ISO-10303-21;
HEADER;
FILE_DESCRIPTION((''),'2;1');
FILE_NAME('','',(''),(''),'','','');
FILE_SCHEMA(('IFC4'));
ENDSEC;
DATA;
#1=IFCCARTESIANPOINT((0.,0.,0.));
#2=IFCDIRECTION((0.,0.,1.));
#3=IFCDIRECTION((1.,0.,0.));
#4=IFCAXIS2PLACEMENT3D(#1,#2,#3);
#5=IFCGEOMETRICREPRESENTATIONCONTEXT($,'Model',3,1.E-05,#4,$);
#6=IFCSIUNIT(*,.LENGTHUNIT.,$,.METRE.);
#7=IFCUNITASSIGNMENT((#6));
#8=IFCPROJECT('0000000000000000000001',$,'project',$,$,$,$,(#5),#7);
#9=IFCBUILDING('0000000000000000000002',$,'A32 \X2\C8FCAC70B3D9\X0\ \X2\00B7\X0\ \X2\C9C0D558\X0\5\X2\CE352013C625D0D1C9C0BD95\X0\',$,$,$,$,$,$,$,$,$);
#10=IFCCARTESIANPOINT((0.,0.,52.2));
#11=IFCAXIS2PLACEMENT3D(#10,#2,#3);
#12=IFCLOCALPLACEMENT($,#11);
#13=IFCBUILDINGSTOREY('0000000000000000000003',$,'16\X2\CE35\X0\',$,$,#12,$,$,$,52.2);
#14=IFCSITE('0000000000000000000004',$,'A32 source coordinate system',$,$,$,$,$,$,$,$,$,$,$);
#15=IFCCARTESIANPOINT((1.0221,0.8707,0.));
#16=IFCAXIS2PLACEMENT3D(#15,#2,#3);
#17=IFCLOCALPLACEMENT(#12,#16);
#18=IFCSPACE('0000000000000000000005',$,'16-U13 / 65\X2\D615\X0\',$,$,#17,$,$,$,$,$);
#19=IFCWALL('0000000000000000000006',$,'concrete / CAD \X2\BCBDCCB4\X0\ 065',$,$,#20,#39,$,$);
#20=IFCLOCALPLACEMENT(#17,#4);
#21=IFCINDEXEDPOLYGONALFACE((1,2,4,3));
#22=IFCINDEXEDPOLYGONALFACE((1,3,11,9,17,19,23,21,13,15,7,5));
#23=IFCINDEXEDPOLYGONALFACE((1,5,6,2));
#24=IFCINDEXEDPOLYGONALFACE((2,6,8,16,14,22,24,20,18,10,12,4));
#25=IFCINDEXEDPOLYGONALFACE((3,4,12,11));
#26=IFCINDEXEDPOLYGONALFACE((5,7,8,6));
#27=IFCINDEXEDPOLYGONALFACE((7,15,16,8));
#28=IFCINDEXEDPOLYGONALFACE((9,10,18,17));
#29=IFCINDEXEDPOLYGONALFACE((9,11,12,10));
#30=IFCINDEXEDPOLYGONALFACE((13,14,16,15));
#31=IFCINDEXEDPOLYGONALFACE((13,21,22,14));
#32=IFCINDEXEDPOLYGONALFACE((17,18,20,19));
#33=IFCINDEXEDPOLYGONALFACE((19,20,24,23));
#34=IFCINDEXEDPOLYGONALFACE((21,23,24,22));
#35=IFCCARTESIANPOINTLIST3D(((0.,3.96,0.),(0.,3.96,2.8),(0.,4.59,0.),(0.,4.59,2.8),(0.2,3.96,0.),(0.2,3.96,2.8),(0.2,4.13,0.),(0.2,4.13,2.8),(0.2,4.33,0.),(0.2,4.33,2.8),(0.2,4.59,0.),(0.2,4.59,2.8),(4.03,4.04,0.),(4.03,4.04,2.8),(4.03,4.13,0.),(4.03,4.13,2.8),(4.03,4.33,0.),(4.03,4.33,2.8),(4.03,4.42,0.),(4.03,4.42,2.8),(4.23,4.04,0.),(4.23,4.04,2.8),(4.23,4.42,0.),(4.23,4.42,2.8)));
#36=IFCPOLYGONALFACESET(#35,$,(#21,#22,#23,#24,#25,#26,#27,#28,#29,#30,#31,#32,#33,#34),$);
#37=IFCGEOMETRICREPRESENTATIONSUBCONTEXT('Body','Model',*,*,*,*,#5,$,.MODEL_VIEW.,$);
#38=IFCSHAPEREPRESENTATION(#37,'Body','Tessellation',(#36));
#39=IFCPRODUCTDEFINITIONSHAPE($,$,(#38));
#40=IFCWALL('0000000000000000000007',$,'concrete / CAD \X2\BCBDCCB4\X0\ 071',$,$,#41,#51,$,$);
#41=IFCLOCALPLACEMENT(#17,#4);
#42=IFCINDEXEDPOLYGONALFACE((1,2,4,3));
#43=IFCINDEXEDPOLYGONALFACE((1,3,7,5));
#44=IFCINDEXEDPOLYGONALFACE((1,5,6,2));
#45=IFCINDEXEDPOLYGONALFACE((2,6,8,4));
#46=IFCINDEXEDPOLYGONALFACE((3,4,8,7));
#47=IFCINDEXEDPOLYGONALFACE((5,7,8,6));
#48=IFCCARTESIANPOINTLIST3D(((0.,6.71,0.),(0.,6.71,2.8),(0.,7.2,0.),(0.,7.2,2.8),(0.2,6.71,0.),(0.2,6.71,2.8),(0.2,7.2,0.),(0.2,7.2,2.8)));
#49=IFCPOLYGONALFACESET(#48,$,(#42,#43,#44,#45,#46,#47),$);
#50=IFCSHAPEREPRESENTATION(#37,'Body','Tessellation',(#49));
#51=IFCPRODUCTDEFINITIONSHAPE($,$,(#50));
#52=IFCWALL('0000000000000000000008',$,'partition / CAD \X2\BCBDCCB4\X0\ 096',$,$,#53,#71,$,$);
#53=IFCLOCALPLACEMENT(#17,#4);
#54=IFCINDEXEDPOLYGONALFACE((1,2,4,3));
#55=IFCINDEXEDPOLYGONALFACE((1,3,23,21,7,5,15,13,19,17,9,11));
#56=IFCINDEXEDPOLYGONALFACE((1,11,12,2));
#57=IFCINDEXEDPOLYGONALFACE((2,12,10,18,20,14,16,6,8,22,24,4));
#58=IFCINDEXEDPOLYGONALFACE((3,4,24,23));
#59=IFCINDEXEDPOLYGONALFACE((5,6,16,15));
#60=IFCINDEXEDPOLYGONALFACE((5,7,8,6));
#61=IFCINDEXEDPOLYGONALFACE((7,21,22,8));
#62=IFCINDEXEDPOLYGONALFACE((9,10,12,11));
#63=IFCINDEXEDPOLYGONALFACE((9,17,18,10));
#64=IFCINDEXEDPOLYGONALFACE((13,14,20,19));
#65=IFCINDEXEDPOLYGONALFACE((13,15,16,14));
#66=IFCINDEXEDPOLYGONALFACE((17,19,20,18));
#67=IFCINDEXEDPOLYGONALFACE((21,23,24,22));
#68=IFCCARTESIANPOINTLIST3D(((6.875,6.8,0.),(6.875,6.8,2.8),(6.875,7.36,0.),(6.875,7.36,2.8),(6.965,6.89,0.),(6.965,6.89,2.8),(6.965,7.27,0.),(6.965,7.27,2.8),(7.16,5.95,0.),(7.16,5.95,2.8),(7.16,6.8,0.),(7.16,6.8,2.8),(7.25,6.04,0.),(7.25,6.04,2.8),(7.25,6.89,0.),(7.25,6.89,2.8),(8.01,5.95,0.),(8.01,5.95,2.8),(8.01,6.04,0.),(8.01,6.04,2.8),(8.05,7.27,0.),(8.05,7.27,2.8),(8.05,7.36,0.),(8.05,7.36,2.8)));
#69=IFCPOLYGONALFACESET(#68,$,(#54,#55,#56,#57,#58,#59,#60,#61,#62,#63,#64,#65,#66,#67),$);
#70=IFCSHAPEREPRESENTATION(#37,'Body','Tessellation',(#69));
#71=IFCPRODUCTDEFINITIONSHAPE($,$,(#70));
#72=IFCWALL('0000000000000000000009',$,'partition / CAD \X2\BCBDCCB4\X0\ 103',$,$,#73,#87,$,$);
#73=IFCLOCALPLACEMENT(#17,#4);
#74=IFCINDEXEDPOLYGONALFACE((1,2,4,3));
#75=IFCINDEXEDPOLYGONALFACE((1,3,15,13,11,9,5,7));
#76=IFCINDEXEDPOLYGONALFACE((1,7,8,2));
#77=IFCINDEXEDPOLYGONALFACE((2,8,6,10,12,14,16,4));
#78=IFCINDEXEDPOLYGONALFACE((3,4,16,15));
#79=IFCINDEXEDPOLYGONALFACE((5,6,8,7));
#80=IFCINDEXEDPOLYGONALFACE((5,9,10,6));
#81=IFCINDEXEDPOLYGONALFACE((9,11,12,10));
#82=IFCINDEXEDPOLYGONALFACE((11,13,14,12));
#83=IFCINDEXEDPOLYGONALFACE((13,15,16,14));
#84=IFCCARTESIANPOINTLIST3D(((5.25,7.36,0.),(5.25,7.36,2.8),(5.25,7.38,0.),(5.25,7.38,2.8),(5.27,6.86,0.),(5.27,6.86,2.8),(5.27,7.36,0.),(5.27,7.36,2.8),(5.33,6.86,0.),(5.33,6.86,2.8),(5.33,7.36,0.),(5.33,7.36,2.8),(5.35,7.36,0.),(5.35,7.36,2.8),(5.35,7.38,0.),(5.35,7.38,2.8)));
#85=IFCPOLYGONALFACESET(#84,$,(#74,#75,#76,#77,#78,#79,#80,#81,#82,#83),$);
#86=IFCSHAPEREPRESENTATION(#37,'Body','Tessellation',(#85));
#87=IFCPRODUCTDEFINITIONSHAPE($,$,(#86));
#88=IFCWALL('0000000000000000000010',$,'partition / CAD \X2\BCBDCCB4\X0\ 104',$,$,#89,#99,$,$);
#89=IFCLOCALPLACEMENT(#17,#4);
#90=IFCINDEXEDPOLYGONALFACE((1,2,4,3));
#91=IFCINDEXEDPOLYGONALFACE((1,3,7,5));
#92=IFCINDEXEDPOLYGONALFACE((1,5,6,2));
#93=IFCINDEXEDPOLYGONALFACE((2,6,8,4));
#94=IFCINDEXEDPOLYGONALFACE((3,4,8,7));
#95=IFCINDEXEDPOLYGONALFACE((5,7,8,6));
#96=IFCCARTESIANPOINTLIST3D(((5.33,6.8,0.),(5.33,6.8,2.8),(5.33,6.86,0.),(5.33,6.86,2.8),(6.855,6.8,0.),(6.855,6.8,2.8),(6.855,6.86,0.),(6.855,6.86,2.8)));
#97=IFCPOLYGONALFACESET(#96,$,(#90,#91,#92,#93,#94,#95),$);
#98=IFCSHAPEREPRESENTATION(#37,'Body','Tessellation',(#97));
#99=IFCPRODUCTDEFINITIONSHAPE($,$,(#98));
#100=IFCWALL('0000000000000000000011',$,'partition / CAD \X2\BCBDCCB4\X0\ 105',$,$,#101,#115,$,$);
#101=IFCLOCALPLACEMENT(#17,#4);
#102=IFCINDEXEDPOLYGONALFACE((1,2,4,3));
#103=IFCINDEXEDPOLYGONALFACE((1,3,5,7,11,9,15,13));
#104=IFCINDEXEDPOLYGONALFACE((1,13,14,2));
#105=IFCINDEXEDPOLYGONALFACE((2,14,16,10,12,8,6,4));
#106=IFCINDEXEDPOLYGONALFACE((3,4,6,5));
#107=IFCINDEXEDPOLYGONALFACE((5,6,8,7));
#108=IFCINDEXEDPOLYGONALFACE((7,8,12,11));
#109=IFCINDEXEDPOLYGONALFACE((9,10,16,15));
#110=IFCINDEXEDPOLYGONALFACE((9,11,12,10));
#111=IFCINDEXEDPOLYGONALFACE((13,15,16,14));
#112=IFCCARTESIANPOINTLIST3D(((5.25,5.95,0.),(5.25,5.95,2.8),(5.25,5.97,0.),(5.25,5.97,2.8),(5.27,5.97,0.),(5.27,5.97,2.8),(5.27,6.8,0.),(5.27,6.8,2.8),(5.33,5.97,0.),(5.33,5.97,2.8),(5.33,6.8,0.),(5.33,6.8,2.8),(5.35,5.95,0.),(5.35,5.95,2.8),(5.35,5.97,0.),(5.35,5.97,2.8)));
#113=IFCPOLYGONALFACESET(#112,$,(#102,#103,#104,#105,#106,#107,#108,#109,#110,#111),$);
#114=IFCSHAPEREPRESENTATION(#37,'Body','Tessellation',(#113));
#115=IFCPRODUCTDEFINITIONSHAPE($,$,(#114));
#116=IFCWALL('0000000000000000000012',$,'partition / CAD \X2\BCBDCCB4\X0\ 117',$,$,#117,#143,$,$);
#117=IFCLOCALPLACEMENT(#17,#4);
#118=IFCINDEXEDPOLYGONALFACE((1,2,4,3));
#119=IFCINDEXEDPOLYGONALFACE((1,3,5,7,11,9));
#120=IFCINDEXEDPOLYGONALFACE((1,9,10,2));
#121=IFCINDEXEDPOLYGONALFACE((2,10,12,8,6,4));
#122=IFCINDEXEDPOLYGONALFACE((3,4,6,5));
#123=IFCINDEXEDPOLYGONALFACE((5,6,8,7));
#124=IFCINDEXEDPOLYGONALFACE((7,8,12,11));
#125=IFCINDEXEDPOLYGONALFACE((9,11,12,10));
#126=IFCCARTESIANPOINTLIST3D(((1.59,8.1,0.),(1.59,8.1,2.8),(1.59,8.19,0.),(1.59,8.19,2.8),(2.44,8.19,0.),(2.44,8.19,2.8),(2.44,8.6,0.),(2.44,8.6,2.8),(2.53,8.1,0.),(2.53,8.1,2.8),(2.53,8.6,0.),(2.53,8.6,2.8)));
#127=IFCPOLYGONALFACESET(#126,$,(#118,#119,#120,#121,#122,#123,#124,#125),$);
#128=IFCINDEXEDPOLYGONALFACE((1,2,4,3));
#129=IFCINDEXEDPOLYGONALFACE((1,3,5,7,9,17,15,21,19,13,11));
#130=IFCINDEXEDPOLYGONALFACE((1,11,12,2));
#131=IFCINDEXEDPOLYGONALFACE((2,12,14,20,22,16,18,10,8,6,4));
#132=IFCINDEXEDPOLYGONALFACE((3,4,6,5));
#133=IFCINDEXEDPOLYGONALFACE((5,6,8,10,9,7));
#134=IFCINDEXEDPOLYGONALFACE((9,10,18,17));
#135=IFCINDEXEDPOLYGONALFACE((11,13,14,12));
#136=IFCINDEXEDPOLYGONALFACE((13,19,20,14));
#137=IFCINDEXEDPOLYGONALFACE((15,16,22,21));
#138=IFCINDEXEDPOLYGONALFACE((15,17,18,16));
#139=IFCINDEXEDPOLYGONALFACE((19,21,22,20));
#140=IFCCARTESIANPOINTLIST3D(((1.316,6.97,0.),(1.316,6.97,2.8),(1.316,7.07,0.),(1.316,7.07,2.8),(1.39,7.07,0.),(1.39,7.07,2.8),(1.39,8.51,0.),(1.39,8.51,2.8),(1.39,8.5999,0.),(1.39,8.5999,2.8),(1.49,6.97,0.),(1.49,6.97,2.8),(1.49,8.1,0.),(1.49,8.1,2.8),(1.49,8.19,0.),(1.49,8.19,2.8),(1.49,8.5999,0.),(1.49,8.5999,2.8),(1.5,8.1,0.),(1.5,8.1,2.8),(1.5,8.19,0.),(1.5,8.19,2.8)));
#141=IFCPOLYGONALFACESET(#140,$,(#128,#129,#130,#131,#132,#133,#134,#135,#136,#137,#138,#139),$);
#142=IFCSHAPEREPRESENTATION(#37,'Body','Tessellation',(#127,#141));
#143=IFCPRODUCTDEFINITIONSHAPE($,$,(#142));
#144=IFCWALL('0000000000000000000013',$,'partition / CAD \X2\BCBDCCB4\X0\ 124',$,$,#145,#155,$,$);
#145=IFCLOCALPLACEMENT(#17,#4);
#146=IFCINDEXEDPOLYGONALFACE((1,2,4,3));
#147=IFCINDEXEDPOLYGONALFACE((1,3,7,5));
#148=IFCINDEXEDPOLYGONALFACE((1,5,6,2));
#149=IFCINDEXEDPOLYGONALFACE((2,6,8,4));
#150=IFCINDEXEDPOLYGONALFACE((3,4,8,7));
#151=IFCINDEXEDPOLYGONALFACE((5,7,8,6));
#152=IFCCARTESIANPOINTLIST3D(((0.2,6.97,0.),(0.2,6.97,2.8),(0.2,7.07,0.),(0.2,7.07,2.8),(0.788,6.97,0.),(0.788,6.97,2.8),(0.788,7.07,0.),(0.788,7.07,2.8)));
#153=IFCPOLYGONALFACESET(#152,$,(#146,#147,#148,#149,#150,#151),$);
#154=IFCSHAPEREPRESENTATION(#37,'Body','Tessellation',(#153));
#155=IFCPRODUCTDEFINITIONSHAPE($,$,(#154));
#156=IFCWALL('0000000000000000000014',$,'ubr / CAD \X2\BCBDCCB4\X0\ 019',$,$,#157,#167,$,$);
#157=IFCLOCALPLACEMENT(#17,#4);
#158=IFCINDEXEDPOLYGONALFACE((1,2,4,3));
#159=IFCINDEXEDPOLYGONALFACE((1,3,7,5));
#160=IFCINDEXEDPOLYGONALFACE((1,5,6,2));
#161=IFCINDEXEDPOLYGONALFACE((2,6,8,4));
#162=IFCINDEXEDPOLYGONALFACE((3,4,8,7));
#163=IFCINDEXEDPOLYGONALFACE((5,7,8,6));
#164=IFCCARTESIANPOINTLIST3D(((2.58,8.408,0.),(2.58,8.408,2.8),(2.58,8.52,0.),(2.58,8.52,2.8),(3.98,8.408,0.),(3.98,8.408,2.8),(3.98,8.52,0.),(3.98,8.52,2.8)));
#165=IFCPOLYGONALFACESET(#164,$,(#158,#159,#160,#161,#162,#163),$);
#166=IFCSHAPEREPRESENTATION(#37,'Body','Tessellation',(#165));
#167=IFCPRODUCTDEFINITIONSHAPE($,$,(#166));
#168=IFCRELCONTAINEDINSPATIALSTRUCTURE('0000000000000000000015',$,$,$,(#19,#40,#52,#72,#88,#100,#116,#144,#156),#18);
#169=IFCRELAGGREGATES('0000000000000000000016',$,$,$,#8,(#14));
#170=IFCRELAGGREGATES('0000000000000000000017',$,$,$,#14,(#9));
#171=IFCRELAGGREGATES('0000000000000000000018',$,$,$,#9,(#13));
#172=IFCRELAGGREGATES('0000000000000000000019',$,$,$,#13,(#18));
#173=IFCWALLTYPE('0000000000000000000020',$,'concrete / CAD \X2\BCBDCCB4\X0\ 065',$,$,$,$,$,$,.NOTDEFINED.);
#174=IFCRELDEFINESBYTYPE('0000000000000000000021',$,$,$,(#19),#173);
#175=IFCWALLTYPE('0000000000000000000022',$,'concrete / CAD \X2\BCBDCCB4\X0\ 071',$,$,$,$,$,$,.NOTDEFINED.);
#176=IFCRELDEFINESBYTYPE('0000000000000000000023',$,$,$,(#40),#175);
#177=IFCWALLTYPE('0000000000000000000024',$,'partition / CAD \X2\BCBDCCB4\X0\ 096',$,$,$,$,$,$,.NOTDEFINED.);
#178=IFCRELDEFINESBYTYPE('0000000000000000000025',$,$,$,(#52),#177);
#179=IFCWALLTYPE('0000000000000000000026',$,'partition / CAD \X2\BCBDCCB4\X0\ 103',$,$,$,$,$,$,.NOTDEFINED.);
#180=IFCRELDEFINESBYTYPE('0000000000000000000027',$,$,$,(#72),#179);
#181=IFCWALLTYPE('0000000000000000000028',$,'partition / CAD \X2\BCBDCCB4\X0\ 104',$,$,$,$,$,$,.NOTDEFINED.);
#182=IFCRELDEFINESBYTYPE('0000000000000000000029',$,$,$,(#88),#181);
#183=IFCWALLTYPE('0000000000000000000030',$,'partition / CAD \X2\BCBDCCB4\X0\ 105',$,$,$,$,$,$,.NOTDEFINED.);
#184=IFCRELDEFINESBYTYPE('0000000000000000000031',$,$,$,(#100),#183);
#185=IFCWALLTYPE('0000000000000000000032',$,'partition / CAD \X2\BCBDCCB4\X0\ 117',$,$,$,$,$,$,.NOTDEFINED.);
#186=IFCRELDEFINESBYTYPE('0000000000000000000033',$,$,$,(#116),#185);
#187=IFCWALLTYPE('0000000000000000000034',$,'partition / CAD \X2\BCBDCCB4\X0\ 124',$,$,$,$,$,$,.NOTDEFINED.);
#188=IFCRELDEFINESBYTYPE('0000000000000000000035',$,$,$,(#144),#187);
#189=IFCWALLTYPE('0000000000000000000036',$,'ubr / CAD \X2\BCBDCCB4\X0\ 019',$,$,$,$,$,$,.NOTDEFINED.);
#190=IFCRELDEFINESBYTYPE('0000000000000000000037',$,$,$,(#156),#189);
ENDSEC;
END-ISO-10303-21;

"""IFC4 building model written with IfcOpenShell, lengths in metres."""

from ifc_helpers import new_model, si_unit, frame, origin, origin_with_axes, place, context, subcontext, project, spatial, polyline, outline, extrude, source, transform, mapped, type_object, type_shapes, element, save


model = new_model("IFC4")

# Units and contexts
model_context = context("Model", 3, precision=1e-05, world=origin_with_axes())
body_context = subcontext(model_context, "Body", "Model", "MODEL_VIEW")
ifc_project = project(units=[si_unit("LENGTHUNIT", "METRE")], contexts=[model_context])

# Site, building, storey, space
storey_placement = place(None, frame((0.0, 0.0, 52.2), z_axis=(0.0, 0.0, 1.0), x_axis=(1.0, 0.0, 0.0)))
space_placement = place(storey_placement, frame((1.0221, 0.8707, 0.0), z_axis=(0.0, 0.0, 1.0), x_axis=(1.0, 0.0, 0.0)))
site = spatial("IfcSite", under=ifc_project, Name="A32 source coordinate system")
building = spatial("IfcBuilding", under=site, Name="A32 주거동 · 지하5층–옥탑지붕")
storey = spatial("IfcBuildingStorey", under=building, at=storey_placement, Name="16층", Elevation=52.2)
space = spatial("IfcSpace", under=storey, at=space_placement, Name="16-U13 / 65형")

# Walls
wall_type_1 = type_object("IfcWallType", Name="concrete / CAD 벽체 065", PredefinedType="NOTDEFINED")
shared_shape_1 = source(origin(), body_context, "Body", "SweptSolid", [
    extrude(outline(polyline([(0.2, 4.59), (0.2, 4.33), (4.03, 4.33), (4.03, 4.42), (4.23, 4.42), (4.23, 4.04), (4.03, 4.04), (4.03, 4.13), (0.2, 4.13), (0.2, 3.96), (0.0, 3.96), (0.0, 4.59), (0.2, 4.59)])), origin(), (0.0, 0.0, 1.0), 2.8),
])
type_shapes(wall_type_1, [shared_shape_1])
wall_1_placement = place(space_placement, origin_with_axes())
element("IfcWall", 1, at=wall_1_placement, inside=space, type_object=wall_type_1, Name="concrete / CAD 벽체 065", context=body_context, shape_type="MappedRepresentation", body=[
    mapped(shared_shape_1, transform((0.0, 0.0, 0.0), scale=1.0)),
])
wall_type_2 = type_object("IfcWallType", Name="concrete / CAD 벽체 071", PredefinedType="NOTDEFINED")
shared_shape_2 = source(origin(), body_context, "Body", "SweptSolid", [
    extrude(outline(polyline([(0.2, 6.71), (0.0, 6.71), (0.0, 7.2), (0.2, 7.2), (0.2, 6.71)])), origin(), (0.0, 0.0, 1.0), 2.8),
])
type_shapes(wall_type_2, [shared_shape_2])
wall_2_placement = place(space_placement, origin_with_axes())
element("IfcWall", 2, at=wall_2_placement, inside=space, type_object=wall_type_2, Name="concrete / CAD 벽체 071", context=body_context, shape_type="MappedRepresentation", body=[
    mapped(shared_shape_2, transform((0.0, 0.0, 0.0), scale=1.0)),
])
wall_type_3 = type_object("IfcWallType", Name="partition / CAD 벽체 096", PredefinedType="NOTDEFINED")
shared_shape_3 = source(origin(), body_context, "Body", "SweptSolid", [
    extrude(outline(polyline([(7.25, 6.04), (8.01, 6.04), (8.01, 5.95), (7.16, 5.95), (7.16, 6.8), (6.875, 6.8), (6.875, 7.36), (8.05, 7.36), (8.05, 7.27), (6.965, 7.27), (6.965, 6.89), (7.25, 6.89), (7.25, 6.04)])), origin(), (0.0, 0.0, 1.0), 2.8),
])
type_shapes(wall_type_3, [shared_shape_3])
wall_3_placement = place(space_placement, origin_with_axes())
element("IfcWall", 3, at=wall_3_placement, inside=space, type_object=wall_type_3, Name="partition / CAD 벽체 096", context=body_context, shape_type="MappedRepresentation", body=[
    mapped(shared_shape_3, transform((0.0, 0.0, 0.0), scale=1.0)),
])
wall_type_4 = type_object("IfcWallType", Name="partition / CAD 벽체 103", PredefinedType="NOTDEFINED")
shared_shape_4 = source(origin(), body_context, "Body", "SweptSolid", [
    extrude(outline(polyline([(5.27, 7.36), (5.25, 7.36), (5.25, 7.38), (5.35, 7.38), (5.35, 7.36), (5.33, 7.36), (5.33, 6.86), (5.27, 6.86), (5.27, 7.36)])), origin(), (0.0, 0.0, 1.0), 2.8),
])
type_shapes(wall_type_4, [shared_shape_4])
wall_4_placement = place(space_placement, origin_with_axes())
element("IfcWall", 4, at=wall_4_placement, inside=space, type_object=wall_type_4, Name="partition / CAD 벽체 103", context=body_context, shape_type="MappedRepresentation", body=[
    mapped(shared_shape_4, transform((0.0, 0.0, 0.0), scale=1.0)),
])
wall_type_5 = type_object("IfcWallType", Name="partition / CAD 벽체 104", PredefinedType="NOTDEFINED")
shared_shape_5 = source(origin(), body_context, "Body", "SweptSolid", [
    extrude(outline(polyline([(6.855, 6.86), (6.855, 6.8), (5.33, 6.8), (5.33, 6.86), (6.855, 6.86)])), origin(), (0.0, 0.0, 1.0), 2.8),
])
type_shapes(wall_type_5, [shared_shape_5])
wall_5_placement = place(space_placement, origin_with_axes())
element("IfcWall", 5, at=wall_5_placement, inside=space, type_object=wall_type_5, Name="partition / CAD 벽체 104", context=body_context, shape_type="MappedRepresentation", body=[
    mapped(shared_shape_5, transform((0.0, 0.0, 0.0), scale=1.0)),
])
wall_type_6 = type_object("IfcWallType", Name="partition / CAD 벽체 105", PredefinedType="NOTDEFINED")
shared_shape_6 = source(origin(), body_context, "Body", "SweptSolid", [
    extrude(outline(polyline([(5.25, 5.97), (5.27, 5.97), (5.27, 6.8), (5.33, 6.8), (5.33, 5.97), (5.35, 5.97), (5.35, 5.95), (5.25, 5.95), (5.25, 5.97)])), origin(), (0.0, 0.0, 1.0), 2.8),
])
type_shapes(wall_type_6, [shared_shape_6])
wall_6_placement = place(space_placement, origin_with_axes())
element("IfcWall", 6, at=wall_6_placement, inside=space, type_object=wall_type_6, Name="partition / CAD 벽체 105", context=body_context, shape_type="MappedRepresentation", body=[
    mapped(shared_shape_6, transform((0.0, 0.0, 0.0), scale=1.0)),
])
wall_type_7 = type_object("IfcWallType", Name="partition / CAD 벽체 117", PredefinedType="NOTDEFINED")
shared_shape_7 = source(origin(), body_context, "Body", "SweptSolid", [
    extrude(outline(polyline([(2.53, 8.1), (1.59, 8.1), (1.59, 8.19), (2.44, 8.19), (2.44, 8.6), (2.53, 8.6), (2.53, 8.1)])), origin(), (0.0, 0.0, 1.0), 2.8),
    extrude(outline(polyline([(1.49, 8.1), (1.49, 6.97), (1.316, 6.97), (1.316, 7.07), (1.39, 7.07), (1.39, 8.51), (1.39, 8.5999), (1.49, 8.5999), (1.49, 8.19), (1.5, 8.19), (1.5, 8.1), (1.49, 8.1)])), origin(), (0.0, 0.0, 1.0), 2.8),
])
type_shapes(wall_type_7, [shared_shape_7])
wall_7_placement = place(space_placement, origin_with_axes())
element("IfcWall", 7, at=wall_7_placement, inside=space, type_object=wall_type_7, Name="partition / CAD 벽체 117", context=body_context, shape_type="MappedRepresentation", body=[
    mapped(shared_shape_7, transform((0.0, 0.0, 0.0), scale=1.0)),
])
wall_type_8 = type_object("IfcWallType", Name="partition / CAD 벽체 124", PredefinedType="NOTDEFINED")
shared_shape_8 = source(origin(), body_context, "Body", "SweptSolid", [
    extrude(outline(polyline([(0.788, 7.07), (0.788, 6.97), (0.2, 6.97), (0.2, 7.07), (0.788, 7.07)])), origin(), (0.0, 0.0, 1.0), 2.8),
])
type_shapes(wall_type_8, [shared_shape_8])
wall_8_placement = place(space_placement, origin_with_axes())
element("IfcWall", 8, at=wall_8_placement, inside=space, type_object=wall_type_8, Name="partition / CAD 벽체 124", context=body_context, shape_type="MappedRepresentation", body=[
    mapped(shared_shape_8, transform((0.0, 0.0, 0.0), scale=1.0)),
])
wall_type_9 = type_object("IfcWallType", Name="ubr / CAD 벽체 019", PredefinedType="NOTDEFINED")
shared_shape_9 = source(origin(), body_context, "Body", "SweptSolid", [
    extrude(outline(polyline([(3.98, 8.408), (2.58, 8.408), (2.58, 8.52), (3.98, 8.52), (3.98, 8.408)])), origin(), (0.0, 0.0, 1.0), 2.8),
])
type_shapes(wall_type_9, [shared_shape_9])
wall_9_placement = place(space_placement, origin_with_axes())
element("IfcWall", 9, at=wall_9_placement, inside=space, type_object=wall_type_9, Name="ubr / CAD 벽체 019", context=body_context, shape_type="MappedRepresentation", body=[
    mapped(shared_shape_9, transform((0.0, 0.0, 0.0), scale=1.0)),
])

save(model, "model.ifc")
